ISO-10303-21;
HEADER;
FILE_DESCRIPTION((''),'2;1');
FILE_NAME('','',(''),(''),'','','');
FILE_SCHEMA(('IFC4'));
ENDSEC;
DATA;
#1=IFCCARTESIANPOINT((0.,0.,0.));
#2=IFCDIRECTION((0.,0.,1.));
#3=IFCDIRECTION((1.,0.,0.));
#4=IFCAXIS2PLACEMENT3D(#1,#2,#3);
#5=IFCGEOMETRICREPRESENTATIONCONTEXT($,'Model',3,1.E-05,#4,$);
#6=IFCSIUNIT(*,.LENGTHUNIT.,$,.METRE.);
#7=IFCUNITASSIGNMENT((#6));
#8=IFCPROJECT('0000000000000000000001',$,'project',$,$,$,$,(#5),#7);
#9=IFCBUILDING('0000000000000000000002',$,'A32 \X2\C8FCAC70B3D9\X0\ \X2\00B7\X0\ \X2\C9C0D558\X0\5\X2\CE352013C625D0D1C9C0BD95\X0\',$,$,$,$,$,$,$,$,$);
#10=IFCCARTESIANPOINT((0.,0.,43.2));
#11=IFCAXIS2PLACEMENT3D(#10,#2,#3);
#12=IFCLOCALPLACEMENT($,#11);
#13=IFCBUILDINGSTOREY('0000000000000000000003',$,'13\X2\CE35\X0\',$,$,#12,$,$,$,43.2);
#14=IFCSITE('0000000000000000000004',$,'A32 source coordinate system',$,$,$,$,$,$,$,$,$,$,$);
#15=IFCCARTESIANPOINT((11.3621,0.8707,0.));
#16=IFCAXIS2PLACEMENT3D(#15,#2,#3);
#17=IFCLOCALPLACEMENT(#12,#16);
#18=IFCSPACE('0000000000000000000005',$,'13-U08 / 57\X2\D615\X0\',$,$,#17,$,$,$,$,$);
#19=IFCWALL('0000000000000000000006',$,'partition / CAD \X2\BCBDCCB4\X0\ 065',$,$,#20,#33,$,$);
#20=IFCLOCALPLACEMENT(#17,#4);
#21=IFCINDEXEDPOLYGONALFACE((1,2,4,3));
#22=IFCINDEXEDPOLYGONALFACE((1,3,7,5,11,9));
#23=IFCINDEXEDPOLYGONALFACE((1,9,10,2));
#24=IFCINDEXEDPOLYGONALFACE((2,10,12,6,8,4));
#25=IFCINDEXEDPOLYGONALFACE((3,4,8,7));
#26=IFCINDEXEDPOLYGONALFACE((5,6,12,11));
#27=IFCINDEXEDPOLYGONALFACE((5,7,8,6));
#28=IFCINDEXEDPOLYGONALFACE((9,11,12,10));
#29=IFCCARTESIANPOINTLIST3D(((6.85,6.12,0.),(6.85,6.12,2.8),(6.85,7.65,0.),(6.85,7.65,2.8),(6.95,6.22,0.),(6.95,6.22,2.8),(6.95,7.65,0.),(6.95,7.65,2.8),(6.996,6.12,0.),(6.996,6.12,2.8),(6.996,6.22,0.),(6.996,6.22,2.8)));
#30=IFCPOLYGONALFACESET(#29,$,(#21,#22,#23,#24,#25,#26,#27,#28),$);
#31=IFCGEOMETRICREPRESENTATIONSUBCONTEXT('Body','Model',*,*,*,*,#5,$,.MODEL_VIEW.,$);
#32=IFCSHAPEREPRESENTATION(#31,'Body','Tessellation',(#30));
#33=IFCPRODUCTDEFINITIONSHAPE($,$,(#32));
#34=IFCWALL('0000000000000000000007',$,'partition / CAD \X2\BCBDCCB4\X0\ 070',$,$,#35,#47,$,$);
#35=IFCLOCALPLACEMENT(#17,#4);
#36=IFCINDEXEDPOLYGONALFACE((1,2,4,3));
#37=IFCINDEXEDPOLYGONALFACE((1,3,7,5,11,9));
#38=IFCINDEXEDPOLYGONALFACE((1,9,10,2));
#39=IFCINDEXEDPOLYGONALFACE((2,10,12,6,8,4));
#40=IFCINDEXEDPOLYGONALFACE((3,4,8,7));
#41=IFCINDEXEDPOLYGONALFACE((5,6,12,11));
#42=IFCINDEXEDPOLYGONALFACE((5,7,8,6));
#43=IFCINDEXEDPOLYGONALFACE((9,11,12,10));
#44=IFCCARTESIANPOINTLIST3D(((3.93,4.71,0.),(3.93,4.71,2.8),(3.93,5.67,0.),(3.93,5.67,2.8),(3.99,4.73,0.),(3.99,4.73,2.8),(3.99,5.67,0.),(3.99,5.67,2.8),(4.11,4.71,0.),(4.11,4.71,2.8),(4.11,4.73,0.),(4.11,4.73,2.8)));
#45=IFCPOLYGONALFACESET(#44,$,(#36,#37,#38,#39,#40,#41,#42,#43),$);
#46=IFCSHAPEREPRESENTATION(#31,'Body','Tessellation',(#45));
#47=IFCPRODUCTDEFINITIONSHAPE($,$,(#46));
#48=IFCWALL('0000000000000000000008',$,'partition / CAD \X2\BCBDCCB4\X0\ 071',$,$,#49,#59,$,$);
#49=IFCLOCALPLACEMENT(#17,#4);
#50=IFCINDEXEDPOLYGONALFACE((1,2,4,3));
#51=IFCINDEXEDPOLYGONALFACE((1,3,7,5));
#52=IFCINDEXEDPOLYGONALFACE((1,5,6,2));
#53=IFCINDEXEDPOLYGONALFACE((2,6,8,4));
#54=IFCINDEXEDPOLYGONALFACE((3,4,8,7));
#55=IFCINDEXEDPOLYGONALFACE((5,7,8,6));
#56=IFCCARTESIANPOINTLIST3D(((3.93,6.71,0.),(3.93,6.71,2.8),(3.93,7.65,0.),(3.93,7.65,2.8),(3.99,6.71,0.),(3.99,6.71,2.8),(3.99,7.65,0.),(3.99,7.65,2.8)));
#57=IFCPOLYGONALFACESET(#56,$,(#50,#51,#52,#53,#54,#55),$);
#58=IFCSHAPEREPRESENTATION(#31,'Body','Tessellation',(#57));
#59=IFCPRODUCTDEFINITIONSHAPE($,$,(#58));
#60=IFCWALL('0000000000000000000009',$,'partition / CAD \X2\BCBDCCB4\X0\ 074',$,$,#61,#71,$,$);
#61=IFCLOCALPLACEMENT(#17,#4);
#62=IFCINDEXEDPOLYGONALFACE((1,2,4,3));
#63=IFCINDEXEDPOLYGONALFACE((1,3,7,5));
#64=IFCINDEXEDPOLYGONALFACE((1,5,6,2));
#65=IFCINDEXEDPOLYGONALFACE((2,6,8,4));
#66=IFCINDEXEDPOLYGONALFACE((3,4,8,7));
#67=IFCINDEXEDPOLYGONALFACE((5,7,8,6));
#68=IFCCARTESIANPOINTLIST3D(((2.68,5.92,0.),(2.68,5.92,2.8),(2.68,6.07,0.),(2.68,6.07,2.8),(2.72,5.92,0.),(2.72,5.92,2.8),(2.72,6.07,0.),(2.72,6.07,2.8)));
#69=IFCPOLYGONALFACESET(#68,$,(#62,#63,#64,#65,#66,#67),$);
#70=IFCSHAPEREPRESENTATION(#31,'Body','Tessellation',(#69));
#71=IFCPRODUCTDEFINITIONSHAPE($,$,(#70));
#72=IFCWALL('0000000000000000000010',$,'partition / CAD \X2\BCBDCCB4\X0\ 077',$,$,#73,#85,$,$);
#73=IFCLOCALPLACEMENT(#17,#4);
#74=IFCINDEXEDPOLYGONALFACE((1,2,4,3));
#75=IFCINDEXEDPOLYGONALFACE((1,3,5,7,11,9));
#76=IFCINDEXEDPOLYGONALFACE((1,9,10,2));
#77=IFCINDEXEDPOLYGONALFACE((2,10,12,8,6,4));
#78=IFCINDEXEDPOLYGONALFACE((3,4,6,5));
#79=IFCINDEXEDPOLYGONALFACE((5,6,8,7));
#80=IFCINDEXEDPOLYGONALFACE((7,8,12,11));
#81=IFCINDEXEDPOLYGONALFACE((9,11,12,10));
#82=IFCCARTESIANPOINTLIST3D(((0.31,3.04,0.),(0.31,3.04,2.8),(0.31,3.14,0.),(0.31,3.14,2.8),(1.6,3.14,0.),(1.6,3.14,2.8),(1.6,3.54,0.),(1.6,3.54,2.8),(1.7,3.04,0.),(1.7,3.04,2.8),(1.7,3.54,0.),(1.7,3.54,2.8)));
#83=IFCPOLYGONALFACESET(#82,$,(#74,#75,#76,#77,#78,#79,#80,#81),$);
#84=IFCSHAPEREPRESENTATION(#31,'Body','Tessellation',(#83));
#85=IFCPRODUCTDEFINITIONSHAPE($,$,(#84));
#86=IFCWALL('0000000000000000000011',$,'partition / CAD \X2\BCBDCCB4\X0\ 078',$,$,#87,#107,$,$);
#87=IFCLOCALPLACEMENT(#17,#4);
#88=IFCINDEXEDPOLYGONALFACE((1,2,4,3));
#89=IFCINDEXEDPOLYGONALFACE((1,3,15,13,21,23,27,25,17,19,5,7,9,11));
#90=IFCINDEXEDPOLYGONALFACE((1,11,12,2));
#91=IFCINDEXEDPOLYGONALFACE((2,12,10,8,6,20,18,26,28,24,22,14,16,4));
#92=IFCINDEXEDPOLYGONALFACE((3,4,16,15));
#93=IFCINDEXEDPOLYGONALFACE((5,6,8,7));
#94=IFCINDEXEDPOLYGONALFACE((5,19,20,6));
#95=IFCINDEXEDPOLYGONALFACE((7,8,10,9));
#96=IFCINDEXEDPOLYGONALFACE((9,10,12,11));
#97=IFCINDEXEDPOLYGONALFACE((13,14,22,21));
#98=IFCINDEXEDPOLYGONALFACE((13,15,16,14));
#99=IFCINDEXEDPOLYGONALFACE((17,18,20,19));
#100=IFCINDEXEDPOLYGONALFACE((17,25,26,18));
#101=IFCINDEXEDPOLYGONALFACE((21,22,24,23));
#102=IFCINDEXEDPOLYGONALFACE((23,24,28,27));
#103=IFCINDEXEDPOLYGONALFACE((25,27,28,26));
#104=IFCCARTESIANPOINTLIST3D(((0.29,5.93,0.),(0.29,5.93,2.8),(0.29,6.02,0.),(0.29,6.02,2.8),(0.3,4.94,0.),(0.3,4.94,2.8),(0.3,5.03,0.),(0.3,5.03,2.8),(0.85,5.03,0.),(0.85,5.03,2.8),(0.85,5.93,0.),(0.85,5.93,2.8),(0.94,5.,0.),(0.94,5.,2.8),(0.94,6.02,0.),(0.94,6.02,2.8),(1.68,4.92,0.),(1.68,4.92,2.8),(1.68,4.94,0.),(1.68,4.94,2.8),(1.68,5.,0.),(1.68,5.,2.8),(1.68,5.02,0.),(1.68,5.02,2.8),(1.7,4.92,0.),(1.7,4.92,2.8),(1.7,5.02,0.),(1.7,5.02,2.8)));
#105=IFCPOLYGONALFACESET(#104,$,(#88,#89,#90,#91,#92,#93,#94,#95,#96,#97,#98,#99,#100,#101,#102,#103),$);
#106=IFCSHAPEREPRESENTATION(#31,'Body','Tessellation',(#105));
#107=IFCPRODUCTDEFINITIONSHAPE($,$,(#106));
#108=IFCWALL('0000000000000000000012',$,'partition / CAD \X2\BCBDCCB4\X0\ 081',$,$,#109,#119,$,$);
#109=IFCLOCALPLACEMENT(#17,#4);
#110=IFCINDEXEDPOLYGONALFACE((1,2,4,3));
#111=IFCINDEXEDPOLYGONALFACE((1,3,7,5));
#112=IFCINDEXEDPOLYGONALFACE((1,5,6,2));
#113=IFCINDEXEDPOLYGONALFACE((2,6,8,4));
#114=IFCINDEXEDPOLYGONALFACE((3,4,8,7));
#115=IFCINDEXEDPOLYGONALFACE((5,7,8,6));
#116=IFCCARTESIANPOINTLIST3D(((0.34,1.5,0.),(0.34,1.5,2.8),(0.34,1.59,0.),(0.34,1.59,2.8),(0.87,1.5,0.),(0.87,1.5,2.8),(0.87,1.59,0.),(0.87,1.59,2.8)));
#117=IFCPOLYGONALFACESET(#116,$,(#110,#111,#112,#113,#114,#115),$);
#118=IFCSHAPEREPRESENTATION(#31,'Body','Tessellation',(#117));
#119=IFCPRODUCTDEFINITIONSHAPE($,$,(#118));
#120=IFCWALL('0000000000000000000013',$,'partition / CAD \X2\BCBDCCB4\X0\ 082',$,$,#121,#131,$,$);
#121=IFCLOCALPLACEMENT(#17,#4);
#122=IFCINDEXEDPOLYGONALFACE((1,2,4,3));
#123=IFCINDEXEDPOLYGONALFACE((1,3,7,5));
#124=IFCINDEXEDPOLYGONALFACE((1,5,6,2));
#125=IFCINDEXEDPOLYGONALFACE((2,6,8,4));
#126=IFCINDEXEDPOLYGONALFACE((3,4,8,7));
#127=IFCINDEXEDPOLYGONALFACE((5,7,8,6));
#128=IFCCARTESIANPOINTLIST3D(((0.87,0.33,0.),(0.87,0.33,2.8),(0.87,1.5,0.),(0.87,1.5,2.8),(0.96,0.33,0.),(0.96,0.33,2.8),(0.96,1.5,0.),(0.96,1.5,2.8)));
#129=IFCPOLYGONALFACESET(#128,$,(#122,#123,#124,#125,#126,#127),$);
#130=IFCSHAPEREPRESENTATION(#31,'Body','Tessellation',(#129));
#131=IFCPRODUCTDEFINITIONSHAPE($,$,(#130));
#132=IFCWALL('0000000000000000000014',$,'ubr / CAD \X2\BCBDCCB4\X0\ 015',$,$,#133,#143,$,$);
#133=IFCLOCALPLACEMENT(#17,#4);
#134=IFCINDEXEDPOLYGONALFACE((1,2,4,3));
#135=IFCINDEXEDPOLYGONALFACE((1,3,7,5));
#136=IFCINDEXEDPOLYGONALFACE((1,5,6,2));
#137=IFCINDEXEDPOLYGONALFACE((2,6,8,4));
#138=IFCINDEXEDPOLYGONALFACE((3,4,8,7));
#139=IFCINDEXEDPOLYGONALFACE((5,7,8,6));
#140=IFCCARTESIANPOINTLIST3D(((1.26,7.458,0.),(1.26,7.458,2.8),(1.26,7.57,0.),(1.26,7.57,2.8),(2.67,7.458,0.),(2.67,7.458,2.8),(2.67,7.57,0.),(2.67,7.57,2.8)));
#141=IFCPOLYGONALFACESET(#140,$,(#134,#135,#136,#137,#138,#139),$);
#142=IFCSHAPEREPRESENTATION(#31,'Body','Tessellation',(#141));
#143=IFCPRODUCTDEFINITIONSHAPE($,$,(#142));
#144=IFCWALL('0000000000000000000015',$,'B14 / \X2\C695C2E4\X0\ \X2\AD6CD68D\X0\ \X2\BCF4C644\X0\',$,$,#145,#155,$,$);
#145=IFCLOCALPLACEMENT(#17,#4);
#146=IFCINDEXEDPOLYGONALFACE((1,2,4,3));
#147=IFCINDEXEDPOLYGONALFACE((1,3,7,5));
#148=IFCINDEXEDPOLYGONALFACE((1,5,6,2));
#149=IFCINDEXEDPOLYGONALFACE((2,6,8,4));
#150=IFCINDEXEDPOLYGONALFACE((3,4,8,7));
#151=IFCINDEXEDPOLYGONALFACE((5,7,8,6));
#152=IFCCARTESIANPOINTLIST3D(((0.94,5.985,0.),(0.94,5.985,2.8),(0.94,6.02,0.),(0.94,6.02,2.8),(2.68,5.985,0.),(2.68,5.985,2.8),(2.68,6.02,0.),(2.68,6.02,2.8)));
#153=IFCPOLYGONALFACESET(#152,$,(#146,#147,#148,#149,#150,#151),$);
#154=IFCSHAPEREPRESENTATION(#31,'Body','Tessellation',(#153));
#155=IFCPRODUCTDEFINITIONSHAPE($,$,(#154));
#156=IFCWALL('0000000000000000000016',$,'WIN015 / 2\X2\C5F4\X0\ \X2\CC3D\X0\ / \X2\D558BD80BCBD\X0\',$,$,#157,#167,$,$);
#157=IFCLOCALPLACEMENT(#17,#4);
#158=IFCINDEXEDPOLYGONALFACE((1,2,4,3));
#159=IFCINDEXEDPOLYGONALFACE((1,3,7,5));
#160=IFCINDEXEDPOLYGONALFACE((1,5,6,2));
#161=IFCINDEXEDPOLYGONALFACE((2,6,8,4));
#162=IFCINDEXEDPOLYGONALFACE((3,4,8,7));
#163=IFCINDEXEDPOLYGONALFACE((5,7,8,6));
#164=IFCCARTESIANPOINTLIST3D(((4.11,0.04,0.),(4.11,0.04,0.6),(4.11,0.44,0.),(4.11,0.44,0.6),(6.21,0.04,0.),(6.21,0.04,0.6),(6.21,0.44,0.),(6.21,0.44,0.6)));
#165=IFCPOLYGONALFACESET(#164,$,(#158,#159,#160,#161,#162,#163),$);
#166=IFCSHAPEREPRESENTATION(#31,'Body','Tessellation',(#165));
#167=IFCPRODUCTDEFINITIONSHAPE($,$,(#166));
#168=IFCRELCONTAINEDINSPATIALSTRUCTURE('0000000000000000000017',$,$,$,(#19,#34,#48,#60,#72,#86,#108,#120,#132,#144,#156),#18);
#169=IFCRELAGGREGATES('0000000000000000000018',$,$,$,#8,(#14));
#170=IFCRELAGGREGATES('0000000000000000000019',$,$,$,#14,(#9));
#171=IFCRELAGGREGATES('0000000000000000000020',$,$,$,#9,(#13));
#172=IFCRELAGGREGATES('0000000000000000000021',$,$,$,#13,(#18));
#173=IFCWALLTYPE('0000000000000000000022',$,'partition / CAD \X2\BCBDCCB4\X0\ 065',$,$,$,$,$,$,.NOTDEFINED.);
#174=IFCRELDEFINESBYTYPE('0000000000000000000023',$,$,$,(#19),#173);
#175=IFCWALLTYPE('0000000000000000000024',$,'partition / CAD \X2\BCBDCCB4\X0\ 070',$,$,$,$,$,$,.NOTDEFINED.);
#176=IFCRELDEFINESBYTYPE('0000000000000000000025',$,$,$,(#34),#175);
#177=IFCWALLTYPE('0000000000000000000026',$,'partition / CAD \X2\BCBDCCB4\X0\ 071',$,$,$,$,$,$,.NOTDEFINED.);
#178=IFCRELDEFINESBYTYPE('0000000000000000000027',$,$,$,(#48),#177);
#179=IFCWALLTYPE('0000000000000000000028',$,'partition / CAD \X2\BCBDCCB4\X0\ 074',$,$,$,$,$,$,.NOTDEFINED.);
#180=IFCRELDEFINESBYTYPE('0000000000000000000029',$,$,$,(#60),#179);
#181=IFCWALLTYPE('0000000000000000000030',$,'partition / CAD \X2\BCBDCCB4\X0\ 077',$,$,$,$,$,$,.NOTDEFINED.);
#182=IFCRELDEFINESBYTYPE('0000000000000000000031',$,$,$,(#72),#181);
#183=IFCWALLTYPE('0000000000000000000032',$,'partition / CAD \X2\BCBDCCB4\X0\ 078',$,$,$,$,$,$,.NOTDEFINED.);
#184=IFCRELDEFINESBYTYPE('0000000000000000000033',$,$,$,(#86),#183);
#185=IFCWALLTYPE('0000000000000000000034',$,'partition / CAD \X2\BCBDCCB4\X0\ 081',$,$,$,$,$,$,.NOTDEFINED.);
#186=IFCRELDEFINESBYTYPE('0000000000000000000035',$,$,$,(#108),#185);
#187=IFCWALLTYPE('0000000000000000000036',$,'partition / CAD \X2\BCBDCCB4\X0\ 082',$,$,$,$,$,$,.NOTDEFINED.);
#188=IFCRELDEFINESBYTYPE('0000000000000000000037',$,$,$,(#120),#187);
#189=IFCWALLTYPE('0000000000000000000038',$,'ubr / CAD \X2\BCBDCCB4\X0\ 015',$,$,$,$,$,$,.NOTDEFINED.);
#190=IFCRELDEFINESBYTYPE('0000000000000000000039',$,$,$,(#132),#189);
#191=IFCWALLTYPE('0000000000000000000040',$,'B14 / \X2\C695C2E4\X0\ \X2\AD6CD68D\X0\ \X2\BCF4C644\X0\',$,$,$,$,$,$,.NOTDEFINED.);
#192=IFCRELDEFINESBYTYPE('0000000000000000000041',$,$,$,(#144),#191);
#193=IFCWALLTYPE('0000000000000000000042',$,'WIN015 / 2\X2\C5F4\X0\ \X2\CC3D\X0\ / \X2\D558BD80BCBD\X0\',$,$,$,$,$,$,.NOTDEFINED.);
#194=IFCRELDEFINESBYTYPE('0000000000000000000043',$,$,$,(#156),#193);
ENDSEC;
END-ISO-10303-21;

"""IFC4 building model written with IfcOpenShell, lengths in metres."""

from ifc_helpers import new_model, si_unit, frame, origin, origin_with_axes, place, context, subcontext, project, spatial, polyline, outline, extrude, source, transform, mapped, type_object, type_shapes, element, save


model = new_model("IFC4")

# Units and contexts
model_context = context("Model", 3, precision=1e-05, world=origin_with_axes())
body_context = subcontext(model_context, "Body", "Model", "MODEL_VIEW")
ifc_project = project(units=[si_unit("LENGTHUNIT", "METRE")], contexts=[model_context])

# Site, building, storey, space
storey_placement = place(None, frame((0.0, 0.0, 43.2), z_axis=(0.0, 0.0, 1.0), x_axis=(1.0, 0.0, 0.0)))
space_placement = place(storey_placement, frame((11.3621, 0.8707, 0.0), z_axis=(0.0, 0.0, 1.0), x_axis=(1.0, 0.0, 0.0)))
site = spatial("IfcSite", under=ifc_project, Name="A32 source coordinate system")
building = spatial("IfcBuilding", under=site, Name="A32 주거동 · 지하5층–옥탑지붕")
storey = spatial("IfcBuildingStorey", under=building, at=storey_placement, Name="13층", Elevation=43.2)
space = spatial("IfcSpace", under=storey, at=space_placement, Name="13-U08 / 57형")

# Walls
wall_type_1 = type_object("IfcWallType", Name="partition / CAD 벽체 065", PredefinedType="NOTDEFINED")
shared_shape_1 = source(origin(), body_context, "Body", "SweptSolid", [
    extrude(outline(polyline([(6.95, 7.65), (6.95, 6.22), (6.996, 6.22), (6.996, 6.12), (6.85, 6.12), (6.85, 7.65), (6.95, 7.65)])), origin(), (0.0, 0.0, 1.0), 2.8),
])
type_shapes(wall_type_1, [shared_shape_1])
wall_1_placement = place(space_placement, origin_with_axes())
element("IfcWall", 1, at=wall_1_placement, inside=space, type_object=wall_type_1, Name="partition / CAD 벽체 065", context=body_context, shape_type="MappedRepresentation", body=[
    mapped(shared_shape_1, transform((0.0, 0.0, 0.0), scale=1.0)),
])
wall_type_2 = type_object("IfcWallType", Name="partition / CAD 벽체 070", PredefinedType="NOTDEFINED")
shared_shape_2 = source(origin(), body_context, "Body", "SweptSolid", [
    extrude(outline(polyline([(4.11, 4.73), (4.11, 4.71), (3.93, 4.71), (3.93, 5.67), (3.99, 5.67), (3.99, 4.73), (4.11, 4.73)])), origin(), (0.0, 0.0, 1.0), 2.8),
])
type_shapes(wall_type_2, [shared_shape_2])
wall_2_placement = place(space_placement, origin_with_axes())
element("IfcWall", 2, at=wall_2_placement, inside=space, type_object=wall_type_2, Name="partition / CAD 벽체 070", context=body_context, shape_type="MappedRepresentation", body=[
    mapped(shared_shape_2, transform((0.0, 0.0, 0.0), scale=1.0)),
])
wall_type_3 = type_object("IfcWallType", Name="partition / CAD 벽체 071", PredefinedType="NOTDEFINED")
shared_shape_3 = source(origin(), body_context, "Body", "SweptSolid", [
    extrude(outline(polyline([(3.93, 6.71), (3.93, 7.65), (3.99, 7.65), (3.99, 6.71), (3.93, 6.71)])), origin(), (0.0, 0.0, 1.0), 2.8),
])
type_shapes(wall_type_3, [shared_shape_3])
wall_3_placement = place(space_placement, origin_with_axes())
element("IfcWall", 3, at=wall_3_placement, inside=space, type_object=wall_type_3, Name="partition / CAD 벽체 071", context=body_context, shape_type="MappedRepresentation", body=[
    mapped(shared_shape_3, transform((0.0, 0.0, 0.0), scale=1.0)),
])
wall_type_4 = type_object("IfcWallType", Name="partition / CAD 벽체 074", PredefinedType="NOTDEFINED")
shared_shape_4 = source(origin(), body_context, "Body", "SweptSolid", [
    extrude(outline(polyline([(2.72, 6.07), (2.72, 5.92), (2.68, 5.92), (2.68, 6.07), (2.72, 6.07)])), origin(), (0.0, 0.0, 1.0), 2.8),
])
type_shapes(wall_type_4, [shared_shape_4])
wall_4_placement = place(space_placement, origin_with_axes())
element("IfcWall", 4, at=wall_4_placement, inside=space, type_object=wall_type_4, Name="partition / CAD 벽체 074", context=body_context, shape_type="MappedRepresentation", body=[
    mapped(shared_shape_4, transform((0.0, 0.0, 0.0), scale=1.0)),
])
wall_type_5 = type_object("IfcWallType", Name="partition / CAD 벽체 077", PredefinedType="NOTDEFINED")
shared_shape_5 = source(origin(), body_context, "Body", "SweptSolid", [
    extrude(outline(polyline([(1.7, 3.54), (1.7, 3.04), (0.31, 3.04), (0.31, 3.14), (1.6, 3.14), (1.6, 3.54), (1.7, 3.54)])), origin(), (0.0, 0.0, 1.0), 2.8),
])
type_shapes(wall_type_5, [shared_shape_5])
wall_5_placement = place(space_placement, origin_with_axes())
element("IfcWall", 5, at=wall_5_placement, inside=space, type_object=wall_type_5, Name="partition / CAD 벽체 077", context=body_context, shape_type="MappedRepresentation", body=[
    mapped(shared_shape_5, transform((0.0, 0.0, 0.0), scale=1.0)),
])
wall_type_6 = type_object("IfcWallType", Name="partition / CAD 벽체 078", PredefinedType="NOTDEFINED")
shared_shape_6 = source(origin(), body_context, "Body", "SweptSolid", [
    extrude(outline(polyline([(1.7, 4.92), (1.68, 4.92), (1.68, 4.94), (0.3, 4.94), (0.3, 5.03), (0.85, 5.03), (0.85, 5.93), (0.29, 5.93), (0.29, 6.02), (0.94, 6.02), (0.94, 5.0), (1.68, 5.0), (1.68, 5.02), (1.7, 5.02), (1.7, 4.92)])), origin(), (0.0, 0.0, 1.0), 2.8),
])
type_shapes(wall_type_6, [shared_shape_6])
wall_6_placement = place(space_placement, origin_with_axes())
element("IfcWall", 6, at=wall_6_placement, inside=space, type_object=wall_type_6, Name="partition / CAD 벽체 078", context=body_context, shape_type="MappedRepresentation", body=[
    mapped(shared_shape_6, transform((0.0, 0.0, 0.0), scale=1.0)),
])
wall_type_7 = type_object("IfcWallType", Name="partition / CAD 벽체 081", PredefinedType="NOTDEFINED")
shared_shape_7 = source(origin(), body_context, "Body", "SweptSolid", [
    extrude(outline(polyline([(0.34, 1.59), (0.87, 1.59), (0.87, 1.5), (0.34, 1.5), (0.34, 1.59)])), origin(), (0.0, 0.0, 1.0), 2.8),
])
type_shapes(wall_type_7, [shared_shape_7])
wall_7_placement = place(space_placement, origin_with_axes())
element("IfcWall", 7, at=wall_7_placement, inside=space, type_object=wall_type_7, Name="partition / CAD 벽체 081", context=body_context, shape_type="MappedRepresentation", body=[
    mapped(shared_shape_7, transform((0.0, 0.0, 0.0), scale=1.0)),
])
wall_type_8 = type_object("IfcWallType", Name="partition / CAD 벽체 082", PredefinedType="NOTDEFINED")
shared_shape_8 = source(origin(), body_context, "Body", "SweptSolid", [
    extrude(outline(polyline([(0.96, 0.33), (0.87, 0.33), (0.87, 1.5), (0.96, 1.5), (0.96, 0.33)])), origin(), (0.0, 0.0, 1.0), 2.8),
])
type_shapes(wall_type_8, [shared_shape_8])
wall_8_placement = place(space_placement, origin_with_axes())
element("IfcWall", 8, at=wall_8_placement, inside=space, type_object=wall_type_8, Name="partition / CAD 벽체 082", context=body_context, shape_type="MappedRepresentation", body=[
    mapped(shared_shape_8, transform((0.0, 0.0, 0.0), scale=1.0)),
])
wall_type_9 = type_object("IfcWallType", Name="ubr / CAD 벽체 015", PredefinedType="NOTDEFINED")
shared_shape_9 = source(origin(), body_context, "Body", "SweptSolid", [
    extrude(outline(polyline([(2.67, 7.57), (2.67, 7.458), (1.26, 7.458), (1.26, 7.57), (2.67, 7.57)])), origin(), (0.0, 0.0, 1.0), 2.8),
])
type_shapes(wall_type_9, [shared_shape_9])
wall_9_placement = place(space_placement, origin_with_axes())
element("IfcWall", 9, at=wall_9_placement, inside=space, type_object=wall_type_9, Name="ubr / CAD 벽체 015", context=body_context, shape_type="MappedRepresentation", body=[
    mapped(shared_shape_9, transform((0.0, 0.0, 0.0), scale=1.0)),
])
wall_type_10 = type_object("IfcWallType", Name="B14 / 욕실 구획 보완", PredefinedType="NOTDEFINED")
shared_shape_10 = source(origin(), body_context, "Body", "SweptSolid", [
    extrude(outline(polyline([(2.68, 5.985), (0.94, 5.985), (0.94, 6.02), (2.68, 6.02), (2.68, 5.985)])), origin(), (0.0, 0.0, 1.0), 2.8),
])
type_shapes(wall_type_10, [shared_shape_10])
wall_10_placement = place(space_placement, origin_with_axes())
element("IfcWall", 10, at=wall_10_placement, inside=space, type_object=wall_type_10, Name="B14 / 욕실 구획 보완", context=body_context, shape_type="MappedRepresentation", body=[
    mapped(shared_shape_10, transform((0.0, 0.0, 0.0), scale=1.0)),
])
wall_type_11 = type_object("IfcWallType", Name="WIN015 / 2열 창 / 하부벽", PredefinedType="NOTDEFINED")
shared_shape_11 = source(origin(), body_context, "Body", "SweptSolid", [
    extrude(outline(polyline([(4.11, 0.04), (4.11, 0.44), (6.21, 0.44), (6.21, 0.04), (4.11, 0.04)])), origin(), (0.0, 0.0, 1.0), 0.6),
])
type_shapes(wall_type_11, [shared_shape_11])
wall_11_placement = place(space_placement, origin_with_axes())
element("IfcWall", 11, at=wall_11_placement, inside=space, type_object=wall_type_11, Name="WIN015 / 2열 창 / 하부벽", context=body_context, shape_type="MappedRepresentation", body=[
    mapped(shared_shape_11, transform((0.0, 0.0, 0.0), scale=1.0)),
])

save(model, "model.ifc")
